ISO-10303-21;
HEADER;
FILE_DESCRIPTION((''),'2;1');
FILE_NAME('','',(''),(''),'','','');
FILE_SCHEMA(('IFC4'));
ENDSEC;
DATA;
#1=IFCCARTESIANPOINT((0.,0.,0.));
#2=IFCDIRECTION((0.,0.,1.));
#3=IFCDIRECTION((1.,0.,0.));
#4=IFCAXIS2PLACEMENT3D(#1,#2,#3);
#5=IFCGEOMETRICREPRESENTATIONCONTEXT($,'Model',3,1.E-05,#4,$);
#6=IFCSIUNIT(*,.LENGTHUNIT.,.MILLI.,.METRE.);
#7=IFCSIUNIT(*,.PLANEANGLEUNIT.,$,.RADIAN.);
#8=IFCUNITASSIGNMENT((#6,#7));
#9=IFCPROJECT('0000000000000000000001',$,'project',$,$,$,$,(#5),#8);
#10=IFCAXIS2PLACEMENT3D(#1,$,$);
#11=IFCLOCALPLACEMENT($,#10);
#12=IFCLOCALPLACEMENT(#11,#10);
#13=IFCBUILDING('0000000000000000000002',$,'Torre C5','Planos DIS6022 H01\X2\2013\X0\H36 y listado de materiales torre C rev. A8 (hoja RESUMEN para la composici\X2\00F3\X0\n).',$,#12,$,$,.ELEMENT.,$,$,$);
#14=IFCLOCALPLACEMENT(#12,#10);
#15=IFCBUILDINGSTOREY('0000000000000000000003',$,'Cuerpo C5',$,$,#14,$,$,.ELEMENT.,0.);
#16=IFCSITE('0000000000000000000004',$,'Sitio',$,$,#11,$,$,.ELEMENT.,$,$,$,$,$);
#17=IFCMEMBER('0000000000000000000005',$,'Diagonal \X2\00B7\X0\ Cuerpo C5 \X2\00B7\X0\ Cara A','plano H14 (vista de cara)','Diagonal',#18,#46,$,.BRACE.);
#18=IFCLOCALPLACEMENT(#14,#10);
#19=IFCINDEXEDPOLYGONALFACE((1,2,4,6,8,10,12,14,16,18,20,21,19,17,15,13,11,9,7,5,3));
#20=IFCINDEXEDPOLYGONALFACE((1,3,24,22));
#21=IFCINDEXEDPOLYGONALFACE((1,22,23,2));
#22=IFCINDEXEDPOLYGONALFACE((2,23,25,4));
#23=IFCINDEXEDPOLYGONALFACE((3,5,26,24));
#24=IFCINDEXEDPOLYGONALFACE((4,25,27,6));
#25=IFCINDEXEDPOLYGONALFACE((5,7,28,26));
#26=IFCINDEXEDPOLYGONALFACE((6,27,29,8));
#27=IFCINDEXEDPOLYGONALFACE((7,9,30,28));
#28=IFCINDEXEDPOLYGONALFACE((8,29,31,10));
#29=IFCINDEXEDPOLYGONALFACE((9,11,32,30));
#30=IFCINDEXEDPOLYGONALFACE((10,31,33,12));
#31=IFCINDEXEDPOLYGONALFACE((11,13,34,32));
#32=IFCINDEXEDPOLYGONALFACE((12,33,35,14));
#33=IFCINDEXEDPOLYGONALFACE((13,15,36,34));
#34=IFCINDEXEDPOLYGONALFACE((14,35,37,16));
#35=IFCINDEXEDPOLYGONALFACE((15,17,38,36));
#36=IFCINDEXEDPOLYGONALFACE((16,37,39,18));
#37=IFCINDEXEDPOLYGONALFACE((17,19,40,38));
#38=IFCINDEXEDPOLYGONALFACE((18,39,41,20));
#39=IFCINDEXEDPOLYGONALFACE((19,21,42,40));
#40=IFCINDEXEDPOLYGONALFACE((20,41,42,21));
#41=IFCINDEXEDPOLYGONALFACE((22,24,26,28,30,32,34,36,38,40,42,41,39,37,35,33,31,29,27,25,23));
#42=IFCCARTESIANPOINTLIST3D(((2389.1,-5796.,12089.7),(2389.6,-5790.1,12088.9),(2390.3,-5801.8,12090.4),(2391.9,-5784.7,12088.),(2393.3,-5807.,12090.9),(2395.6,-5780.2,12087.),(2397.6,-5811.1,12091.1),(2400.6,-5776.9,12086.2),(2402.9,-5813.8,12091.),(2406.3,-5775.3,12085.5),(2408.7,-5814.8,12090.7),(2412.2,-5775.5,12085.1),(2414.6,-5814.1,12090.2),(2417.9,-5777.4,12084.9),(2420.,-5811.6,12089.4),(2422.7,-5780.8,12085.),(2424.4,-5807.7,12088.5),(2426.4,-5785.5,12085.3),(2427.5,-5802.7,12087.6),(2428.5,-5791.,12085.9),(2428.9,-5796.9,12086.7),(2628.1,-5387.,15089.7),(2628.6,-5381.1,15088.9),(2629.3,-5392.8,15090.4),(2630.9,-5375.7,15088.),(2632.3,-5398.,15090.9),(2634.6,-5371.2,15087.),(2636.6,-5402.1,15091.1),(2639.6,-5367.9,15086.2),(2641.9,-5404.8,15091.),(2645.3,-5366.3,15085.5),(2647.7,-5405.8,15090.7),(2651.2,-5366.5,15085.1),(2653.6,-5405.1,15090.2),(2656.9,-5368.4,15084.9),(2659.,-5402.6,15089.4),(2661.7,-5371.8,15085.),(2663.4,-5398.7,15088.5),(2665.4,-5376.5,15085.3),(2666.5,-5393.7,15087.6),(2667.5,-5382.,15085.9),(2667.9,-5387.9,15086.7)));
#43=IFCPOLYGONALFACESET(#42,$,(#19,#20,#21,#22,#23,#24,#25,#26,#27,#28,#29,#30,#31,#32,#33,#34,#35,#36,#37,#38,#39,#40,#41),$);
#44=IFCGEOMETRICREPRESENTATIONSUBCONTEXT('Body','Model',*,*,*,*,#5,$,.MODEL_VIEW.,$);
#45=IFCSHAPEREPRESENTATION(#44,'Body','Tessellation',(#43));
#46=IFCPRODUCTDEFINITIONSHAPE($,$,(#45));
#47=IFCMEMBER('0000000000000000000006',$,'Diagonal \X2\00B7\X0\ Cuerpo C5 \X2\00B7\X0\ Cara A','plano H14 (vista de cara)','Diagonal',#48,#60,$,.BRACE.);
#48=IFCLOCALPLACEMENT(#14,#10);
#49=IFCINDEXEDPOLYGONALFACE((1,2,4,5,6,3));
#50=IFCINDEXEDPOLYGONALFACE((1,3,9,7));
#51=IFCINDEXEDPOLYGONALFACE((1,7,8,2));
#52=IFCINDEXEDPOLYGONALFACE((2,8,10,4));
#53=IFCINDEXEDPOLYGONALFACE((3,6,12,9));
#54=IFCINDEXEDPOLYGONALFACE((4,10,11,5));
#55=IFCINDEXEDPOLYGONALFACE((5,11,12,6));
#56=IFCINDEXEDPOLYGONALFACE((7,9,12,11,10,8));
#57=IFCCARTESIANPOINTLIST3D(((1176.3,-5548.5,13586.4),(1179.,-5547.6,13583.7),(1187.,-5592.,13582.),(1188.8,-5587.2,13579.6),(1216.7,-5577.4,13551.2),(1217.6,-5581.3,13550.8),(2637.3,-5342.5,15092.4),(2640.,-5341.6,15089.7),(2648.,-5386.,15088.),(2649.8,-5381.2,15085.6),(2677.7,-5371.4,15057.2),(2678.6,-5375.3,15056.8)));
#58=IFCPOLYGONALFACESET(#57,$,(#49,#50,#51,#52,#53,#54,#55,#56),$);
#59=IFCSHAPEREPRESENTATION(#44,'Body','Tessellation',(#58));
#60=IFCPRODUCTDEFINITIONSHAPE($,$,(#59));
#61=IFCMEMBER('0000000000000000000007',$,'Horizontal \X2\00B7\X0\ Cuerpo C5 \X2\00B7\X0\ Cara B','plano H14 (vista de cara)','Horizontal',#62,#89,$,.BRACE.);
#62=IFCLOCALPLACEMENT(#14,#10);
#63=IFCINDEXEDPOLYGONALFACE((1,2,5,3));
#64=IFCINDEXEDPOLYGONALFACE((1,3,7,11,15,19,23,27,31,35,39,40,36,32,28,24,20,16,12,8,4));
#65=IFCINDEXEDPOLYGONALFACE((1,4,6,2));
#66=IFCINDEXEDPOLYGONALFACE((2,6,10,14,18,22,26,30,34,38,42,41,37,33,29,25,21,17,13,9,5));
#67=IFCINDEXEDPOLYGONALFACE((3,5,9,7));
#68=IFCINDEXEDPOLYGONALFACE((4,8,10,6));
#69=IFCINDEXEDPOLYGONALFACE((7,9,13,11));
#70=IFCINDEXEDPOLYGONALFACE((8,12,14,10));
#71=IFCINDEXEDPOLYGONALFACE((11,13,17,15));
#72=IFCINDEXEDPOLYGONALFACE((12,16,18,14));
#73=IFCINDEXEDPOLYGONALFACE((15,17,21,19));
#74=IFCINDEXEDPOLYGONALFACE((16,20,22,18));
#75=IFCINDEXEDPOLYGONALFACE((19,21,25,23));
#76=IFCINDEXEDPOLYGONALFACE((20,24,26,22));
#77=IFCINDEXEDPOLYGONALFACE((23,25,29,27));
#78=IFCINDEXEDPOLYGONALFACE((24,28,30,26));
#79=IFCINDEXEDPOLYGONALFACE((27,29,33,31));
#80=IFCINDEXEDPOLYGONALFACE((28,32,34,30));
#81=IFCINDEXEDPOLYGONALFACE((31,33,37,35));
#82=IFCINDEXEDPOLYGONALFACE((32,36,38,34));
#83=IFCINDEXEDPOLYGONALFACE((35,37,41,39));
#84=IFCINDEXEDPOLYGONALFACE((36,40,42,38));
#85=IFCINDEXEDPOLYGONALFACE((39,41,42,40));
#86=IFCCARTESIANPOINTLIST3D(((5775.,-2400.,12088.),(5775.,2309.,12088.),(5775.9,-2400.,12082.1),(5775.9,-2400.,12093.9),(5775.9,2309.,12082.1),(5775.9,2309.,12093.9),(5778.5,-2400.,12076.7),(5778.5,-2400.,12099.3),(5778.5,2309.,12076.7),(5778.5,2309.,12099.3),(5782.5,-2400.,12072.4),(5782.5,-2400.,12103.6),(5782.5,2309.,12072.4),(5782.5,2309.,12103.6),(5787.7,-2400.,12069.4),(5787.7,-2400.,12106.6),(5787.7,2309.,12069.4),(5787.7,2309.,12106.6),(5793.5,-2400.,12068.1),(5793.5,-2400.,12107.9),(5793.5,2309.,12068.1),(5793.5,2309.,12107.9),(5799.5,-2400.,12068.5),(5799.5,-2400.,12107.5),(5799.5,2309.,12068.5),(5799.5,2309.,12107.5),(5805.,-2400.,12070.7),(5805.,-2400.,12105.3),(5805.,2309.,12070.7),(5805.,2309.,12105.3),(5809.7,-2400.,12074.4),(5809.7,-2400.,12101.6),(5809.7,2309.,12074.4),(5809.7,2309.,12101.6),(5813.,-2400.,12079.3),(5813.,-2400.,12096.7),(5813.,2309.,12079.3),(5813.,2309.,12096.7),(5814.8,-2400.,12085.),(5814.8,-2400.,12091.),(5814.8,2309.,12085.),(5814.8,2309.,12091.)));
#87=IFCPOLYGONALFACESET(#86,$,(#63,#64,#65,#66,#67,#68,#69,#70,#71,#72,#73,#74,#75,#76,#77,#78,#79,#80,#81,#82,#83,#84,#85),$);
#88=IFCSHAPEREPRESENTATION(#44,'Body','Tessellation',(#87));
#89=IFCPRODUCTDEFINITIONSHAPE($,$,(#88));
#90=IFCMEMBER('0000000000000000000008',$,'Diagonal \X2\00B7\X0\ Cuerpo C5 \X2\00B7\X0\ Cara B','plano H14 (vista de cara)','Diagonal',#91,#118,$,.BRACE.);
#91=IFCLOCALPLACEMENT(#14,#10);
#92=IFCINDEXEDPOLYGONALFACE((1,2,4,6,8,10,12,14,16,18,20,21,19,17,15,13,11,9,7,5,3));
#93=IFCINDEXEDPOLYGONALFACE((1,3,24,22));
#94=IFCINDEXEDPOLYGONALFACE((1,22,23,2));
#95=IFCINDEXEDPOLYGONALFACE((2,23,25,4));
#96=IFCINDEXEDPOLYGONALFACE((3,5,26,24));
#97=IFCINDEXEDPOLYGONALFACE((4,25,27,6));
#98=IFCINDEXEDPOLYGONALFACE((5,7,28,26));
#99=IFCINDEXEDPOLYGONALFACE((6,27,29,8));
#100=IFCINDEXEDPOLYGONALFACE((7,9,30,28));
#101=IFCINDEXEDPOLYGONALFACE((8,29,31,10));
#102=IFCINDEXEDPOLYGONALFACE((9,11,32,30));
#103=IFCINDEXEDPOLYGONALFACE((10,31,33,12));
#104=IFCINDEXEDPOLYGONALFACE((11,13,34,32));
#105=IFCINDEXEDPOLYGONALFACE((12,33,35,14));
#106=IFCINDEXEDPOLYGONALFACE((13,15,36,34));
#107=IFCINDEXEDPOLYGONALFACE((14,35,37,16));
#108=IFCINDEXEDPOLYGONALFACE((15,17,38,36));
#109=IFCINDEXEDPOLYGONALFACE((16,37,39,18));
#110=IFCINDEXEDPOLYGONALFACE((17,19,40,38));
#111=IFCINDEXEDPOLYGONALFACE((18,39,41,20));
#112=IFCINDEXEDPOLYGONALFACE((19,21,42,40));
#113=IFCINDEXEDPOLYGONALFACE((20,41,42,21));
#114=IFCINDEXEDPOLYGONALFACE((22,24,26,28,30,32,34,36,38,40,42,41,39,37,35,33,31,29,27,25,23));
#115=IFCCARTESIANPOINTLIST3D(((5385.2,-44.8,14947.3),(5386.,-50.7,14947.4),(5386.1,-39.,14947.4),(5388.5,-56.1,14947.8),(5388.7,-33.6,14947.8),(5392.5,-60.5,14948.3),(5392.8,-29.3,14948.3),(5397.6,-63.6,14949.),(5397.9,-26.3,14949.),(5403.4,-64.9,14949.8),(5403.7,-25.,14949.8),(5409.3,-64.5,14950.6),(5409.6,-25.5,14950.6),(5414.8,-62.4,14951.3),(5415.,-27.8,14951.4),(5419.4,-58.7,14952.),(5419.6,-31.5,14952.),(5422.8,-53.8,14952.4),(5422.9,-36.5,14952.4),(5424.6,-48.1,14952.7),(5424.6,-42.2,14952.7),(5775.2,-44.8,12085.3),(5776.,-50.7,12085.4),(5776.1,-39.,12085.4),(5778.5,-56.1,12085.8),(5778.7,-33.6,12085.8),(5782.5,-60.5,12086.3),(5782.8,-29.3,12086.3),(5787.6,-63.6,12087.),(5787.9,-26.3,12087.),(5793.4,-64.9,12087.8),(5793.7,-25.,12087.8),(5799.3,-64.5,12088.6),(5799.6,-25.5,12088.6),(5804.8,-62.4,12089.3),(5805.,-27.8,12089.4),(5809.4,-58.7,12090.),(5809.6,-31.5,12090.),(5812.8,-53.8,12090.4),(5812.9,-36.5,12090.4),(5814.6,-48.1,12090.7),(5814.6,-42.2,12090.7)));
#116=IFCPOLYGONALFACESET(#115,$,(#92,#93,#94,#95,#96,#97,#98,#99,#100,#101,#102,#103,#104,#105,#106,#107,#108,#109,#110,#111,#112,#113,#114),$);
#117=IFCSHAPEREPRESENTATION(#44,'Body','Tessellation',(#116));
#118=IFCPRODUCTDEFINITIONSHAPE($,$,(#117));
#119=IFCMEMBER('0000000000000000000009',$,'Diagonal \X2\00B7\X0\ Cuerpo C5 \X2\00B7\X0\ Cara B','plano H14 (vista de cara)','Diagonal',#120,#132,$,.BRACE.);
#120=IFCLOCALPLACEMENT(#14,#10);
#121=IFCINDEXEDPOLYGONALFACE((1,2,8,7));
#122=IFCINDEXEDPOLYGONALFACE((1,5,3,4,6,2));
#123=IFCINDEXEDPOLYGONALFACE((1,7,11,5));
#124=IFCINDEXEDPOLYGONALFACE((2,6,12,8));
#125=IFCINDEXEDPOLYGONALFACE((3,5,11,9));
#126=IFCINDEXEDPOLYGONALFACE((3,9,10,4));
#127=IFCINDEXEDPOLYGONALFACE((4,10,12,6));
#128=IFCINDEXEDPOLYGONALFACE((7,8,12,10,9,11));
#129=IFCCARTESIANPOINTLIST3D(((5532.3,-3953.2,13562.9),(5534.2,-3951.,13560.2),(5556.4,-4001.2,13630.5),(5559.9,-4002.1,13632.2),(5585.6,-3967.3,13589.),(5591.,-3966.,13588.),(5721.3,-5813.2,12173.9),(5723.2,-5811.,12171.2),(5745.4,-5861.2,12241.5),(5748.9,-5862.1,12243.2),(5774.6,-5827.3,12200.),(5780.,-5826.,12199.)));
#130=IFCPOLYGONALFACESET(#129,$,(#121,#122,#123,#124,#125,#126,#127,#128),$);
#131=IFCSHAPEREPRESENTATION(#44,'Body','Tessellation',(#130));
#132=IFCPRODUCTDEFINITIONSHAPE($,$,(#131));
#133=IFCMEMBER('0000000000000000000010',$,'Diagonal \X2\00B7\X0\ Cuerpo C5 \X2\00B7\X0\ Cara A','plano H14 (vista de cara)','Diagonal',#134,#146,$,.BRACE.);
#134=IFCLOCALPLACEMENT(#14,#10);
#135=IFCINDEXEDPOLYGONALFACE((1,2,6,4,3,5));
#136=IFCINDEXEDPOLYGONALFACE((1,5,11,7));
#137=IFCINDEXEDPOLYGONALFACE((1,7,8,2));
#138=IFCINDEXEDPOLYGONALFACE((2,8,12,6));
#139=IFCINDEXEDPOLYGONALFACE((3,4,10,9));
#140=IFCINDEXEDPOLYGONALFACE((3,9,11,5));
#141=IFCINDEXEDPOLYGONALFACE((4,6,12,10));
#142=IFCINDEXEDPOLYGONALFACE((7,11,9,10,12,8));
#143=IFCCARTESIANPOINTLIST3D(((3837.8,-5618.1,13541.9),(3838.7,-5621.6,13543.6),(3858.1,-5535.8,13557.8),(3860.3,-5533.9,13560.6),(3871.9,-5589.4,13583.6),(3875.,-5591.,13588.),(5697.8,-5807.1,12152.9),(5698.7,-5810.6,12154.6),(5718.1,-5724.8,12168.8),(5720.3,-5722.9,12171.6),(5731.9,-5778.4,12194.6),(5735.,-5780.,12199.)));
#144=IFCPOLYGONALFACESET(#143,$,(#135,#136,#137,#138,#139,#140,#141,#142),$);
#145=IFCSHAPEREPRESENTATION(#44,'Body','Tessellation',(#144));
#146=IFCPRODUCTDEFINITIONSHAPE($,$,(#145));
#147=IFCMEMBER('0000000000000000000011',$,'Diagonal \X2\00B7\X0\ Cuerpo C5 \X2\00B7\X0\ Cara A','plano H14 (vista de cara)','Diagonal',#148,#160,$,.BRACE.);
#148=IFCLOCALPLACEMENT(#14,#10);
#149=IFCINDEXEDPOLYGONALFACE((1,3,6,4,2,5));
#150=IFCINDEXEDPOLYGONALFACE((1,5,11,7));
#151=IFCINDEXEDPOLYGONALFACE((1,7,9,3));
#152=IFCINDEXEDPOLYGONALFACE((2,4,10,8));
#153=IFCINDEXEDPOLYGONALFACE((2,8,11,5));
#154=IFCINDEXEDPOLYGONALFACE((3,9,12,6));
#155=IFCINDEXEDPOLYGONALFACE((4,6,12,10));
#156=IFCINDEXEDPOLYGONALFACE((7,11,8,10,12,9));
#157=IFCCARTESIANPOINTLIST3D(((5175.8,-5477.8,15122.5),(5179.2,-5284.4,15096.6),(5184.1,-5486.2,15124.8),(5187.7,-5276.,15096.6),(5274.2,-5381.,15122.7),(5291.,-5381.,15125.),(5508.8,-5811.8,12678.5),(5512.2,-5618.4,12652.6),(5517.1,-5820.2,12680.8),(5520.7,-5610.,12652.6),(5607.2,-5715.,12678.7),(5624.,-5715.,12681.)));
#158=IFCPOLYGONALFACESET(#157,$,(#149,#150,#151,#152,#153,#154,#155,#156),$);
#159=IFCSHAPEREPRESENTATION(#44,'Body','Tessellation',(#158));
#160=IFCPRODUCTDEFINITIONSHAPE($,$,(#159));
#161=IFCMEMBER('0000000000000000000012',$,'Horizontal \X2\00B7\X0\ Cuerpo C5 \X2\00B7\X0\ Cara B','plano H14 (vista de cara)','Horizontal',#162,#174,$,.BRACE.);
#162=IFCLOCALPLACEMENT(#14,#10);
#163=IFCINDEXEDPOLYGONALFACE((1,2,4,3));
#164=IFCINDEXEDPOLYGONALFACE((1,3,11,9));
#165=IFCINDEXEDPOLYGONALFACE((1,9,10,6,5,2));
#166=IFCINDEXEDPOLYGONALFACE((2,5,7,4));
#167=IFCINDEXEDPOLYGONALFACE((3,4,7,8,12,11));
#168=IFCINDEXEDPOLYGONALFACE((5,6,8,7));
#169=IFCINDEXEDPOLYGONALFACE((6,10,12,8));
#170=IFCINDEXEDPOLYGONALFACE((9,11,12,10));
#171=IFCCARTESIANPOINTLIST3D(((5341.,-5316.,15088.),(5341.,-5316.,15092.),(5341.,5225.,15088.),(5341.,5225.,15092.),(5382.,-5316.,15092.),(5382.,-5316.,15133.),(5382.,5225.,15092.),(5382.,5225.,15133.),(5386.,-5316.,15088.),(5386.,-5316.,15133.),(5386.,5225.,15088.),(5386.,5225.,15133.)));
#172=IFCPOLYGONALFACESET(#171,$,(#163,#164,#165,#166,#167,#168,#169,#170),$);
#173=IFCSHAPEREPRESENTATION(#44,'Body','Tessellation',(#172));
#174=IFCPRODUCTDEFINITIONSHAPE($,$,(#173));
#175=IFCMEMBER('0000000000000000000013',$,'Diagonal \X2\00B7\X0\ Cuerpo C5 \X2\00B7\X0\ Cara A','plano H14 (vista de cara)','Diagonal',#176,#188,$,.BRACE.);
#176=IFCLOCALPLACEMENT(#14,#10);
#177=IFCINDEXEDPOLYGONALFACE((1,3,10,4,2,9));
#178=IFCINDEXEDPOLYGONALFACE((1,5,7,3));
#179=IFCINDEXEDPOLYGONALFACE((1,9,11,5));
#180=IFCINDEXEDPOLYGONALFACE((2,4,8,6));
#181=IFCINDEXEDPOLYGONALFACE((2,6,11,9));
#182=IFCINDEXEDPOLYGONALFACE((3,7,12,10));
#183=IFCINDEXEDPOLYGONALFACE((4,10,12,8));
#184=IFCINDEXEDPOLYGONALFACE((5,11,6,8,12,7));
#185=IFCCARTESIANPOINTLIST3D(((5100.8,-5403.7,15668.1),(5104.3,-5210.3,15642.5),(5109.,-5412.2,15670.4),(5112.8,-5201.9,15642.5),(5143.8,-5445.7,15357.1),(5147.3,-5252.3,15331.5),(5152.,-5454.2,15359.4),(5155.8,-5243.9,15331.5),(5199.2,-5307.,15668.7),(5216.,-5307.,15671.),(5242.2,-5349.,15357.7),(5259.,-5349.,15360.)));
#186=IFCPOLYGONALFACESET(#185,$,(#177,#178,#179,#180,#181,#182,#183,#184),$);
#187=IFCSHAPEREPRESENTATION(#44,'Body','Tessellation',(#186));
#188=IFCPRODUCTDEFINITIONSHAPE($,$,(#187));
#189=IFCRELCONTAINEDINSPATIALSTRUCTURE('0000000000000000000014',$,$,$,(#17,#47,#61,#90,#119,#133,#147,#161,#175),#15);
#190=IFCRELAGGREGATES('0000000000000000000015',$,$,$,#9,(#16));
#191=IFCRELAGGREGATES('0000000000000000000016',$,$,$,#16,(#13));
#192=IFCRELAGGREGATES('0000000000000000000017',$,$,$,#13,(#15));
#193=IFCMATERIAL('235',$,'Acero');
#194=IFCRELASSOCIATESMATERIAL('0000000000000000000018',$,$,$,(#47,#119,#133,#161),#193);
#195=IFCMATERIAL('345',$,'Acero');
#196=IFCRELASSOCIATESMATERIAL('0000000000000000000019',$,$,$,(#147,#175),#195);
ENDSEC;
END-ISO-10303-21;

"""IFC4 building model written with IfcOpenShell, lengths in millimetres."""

from ifc_helpers import new_model, si_unit, frame, frame_2d, origin, origin_with_axes, place, context, subcontext, project, spatial, circle, l_section, extrude, material, element, save


model = new_model("IFC4")

# Units and contexts
model_context = context("Model", 3, precision=1e-05, world=origin_with_axes())
body_context = subcontext(model_context, "Body", "Model", "MODEL_VIEW")
ifc_project = project(units=[si_unit("LENGTHUNIT", "METRE", prefix="MILLI"), si_unit("PLANEANGLEUNIT", "RADIAN")], contexts=[model_context])

# Site, building, storey
site_placement = place(None, origin())
site = spatial("IfcSite", under=ifc_project, at=site_placement, Name="Sitio", CompositionType="ELEMENT")
building_placement = place(site_placement, origin())
building = spatial("IfcBuilding", under=site, at=building_placement, Name="Torre C5", Description="Planos DIS6022 H01–H36 y listado de materiales torre C rev. A8 (hoja RESUMEN para la composición).", CompositionType="ELEMENT")
storey_placement = place(building_placement, origin())
storey = spatial("IfcBuildingStorey", under=building, at=storey_placement, Name="Cuerpo C5", CompositionType="ELEMENT", Elevation=0.0)

# Members
ifc_material_1 = material(Name="235", Category="Acero")
member_1_placement = place(storey_placement, frame((2409.0, -5795.0, 12088.0), z_axis=(0.078692, 0.134665, 0.987762), x_axis=(-0.420917, 0.90267, -0.089531)))
element("IfcMember", 1, at=member_1_placement, inside=storey, Name="Diagonal · Cuerpo C5 · Cara A", Description="plano H14 (vista de cara)", ObjectType="Diagonal", PredefinedType="BRACE", context=body_context, shape_type="SweptSolid", body=[
    extrude(circle(Radius=20.0), None, (0.0, 0.0, 1.0), 3037.2),
])
member_2_placement = place(storey_placement, frame((2648.0, -5386.0, 15088.0), z_axis=(-0.69297, -0.097708, -0.714314), x_axis=(-0.237561, 0.966389, 0.098273)))
element("IfcMember", 2, at=member_2_placement, inside=storey, material=ifc_material_1, Name="Diagonal · Cuerpo C5 · Cara A", Description="plano H14 (vista de cara)", ObjectType="Diagonal", PredefinedType="BRACE", context=body_context, shape_type="SweptSolid", body=[
    extrude(l_section(Depth=45.0, Width=45.0, Thickness=4.0, at=frame_2d((22.5, 22.5))), None, (0.0, 0.0, 1.0), 2108.3),
])
member_3_placement = place(storey_placement, frame((5795.0, -2400.0, 12088.0), z_axis=(0.0, 1.0, 0.0), x_axis=(-1.0, 0.0, 0.0)))
element("IfcMember", 3, at=member_3_placement, inside=storey, Name="Horizontal · Cuerpo C5 · Cara B", Description="plano H14 (vista de cara)", ObjectType="Horizontal", PredefinedType="BRACE", context=body_context, shape_type="SweptSolid", body=[
    extrude(circle(Radius=20.0), None, (0.0, 0.0, 1.0), 4709.0),
])
member_4_placement = place(storey_placement, frame((5405.0, -45.0, 14950.0), z_axis=(0.135021, 0.0, -0.990843), x_axis=(-0.99081, 0.00811, -0.135016)))
element("IfcMember", 4, at=member_4_placement, inside=storey, Name="Diagonal · Cuerpo C5 · Cara B", Description="plano H14 (vista de cara)", ObjectType="Diagonal", PredefinedType="BRACE", context=body_context, shape_type="SweptSolid", body=[
    extrude(circle(Radius=20.0), None, (0.0, 0.0, 1.0), 2888.5),
])
for number, where, z_axis, x_axis, name in (
    (5, (5780.0, -5826.0, 12199.0), (-0.081148, 0.798597, 0.596371), (-0.874162, 0.230414, -0.427492), "Diagonal · Cuerpo C5 · Cara B"),
    (6, (5735.0, -5780.0, 12199.0), (-0.798597, 0.081148, 0.596371), (-0.225777, 0.878118, -0.421821), "Diagonal · Cuerpo C5 · Cara A"),
):
    element("IfcMember", number, at=place(storey_placement, frame(where, z_axis=z_axis, x_axis=x_axis)), inside=storey, material=ifc_material_1, Name=name, Description="plano H14 (vista de cara)", ObjectType="Diagonal", PredefinedType="BRACE", context=body_context, shape_type="SweptSolid", body=[
        extrude(l_section(Depth=65.0, Width=65.0, Thickness=4.0, at=frame_2d((32.5, 32.5))), None, (0.0, 0.0, 1.0), 2329.1),
    ])
ifc_material_2 = material(Name="345", Category="Acero")
member_5_placement = place(storey_placement, frame((5624.0, -5715.0, 12681.0), z_axis=(-0.133784, 0.134185, 0.981884), x_axis=(-0.68839, 0.700155, -0.189479)))
element("IfcMember", 7, at=member_5_placement, inside=storey, material=ifc_material_2, Name="Diagonal · Cuerpo C5 · Cara A", Description="plano H14 (vista de cara)", ObjectType="Diagonal", PredefinedType="BRACE", context=body_context, shape_type="SweptSolid", body=[
    extrude(l_section(Depth=150.0, Width=150.0, Thickness=12.0, at=frame_2d((75.0, 75.0))), None, (0.0, 0.0, 1.0), 2489.1),
])
member_6_placement = place(storey_placement, frame((5386.0, -5316.0, 15088.0), z_axis=(0.0, 1.0, 0.0), x_axis=(-1.0, 0.0, 0.0)))
element("IfcMember", 8, at=member_6_placement, inside=storey, material=ifc_material_1, Name="Horizontal · Cuerpo C5 · Cara B", Description="plano H14 (vista de cara)", ObjectType="Horizontal", PredefinedType="BRACE", context=body_context, shape_type="SweptSolid", body=[
    extrude(l_section(Depth=45.0, Width=45.0, Thickness=4.0, at=frame_2d((22.5, 22.5))), None, (0.0, 0.0, 1.0), 10541.0),
])
member_7_placement = place(storey_placement, frame((5259.0, -5349.0, 15360.0), z_axis=(-0.135751, 0.132594, 0.98183), x_axis=(-0.68776, 0.700708, -0.189722)))
element("IfcMember", 9, at=member_7_placement, inside=storey, material=ifc_material_2, Name="Diagonal · Cuerpo C5 · Cara A", Description="plano H14 (vista de cara)", ObjectType="Diagonal", PredefinedType="BRACE", context=body_context, shape_type="SweptSolid", body=[
    extrude(l_section(Depth=150.0, Width=150.0, Thickness=12.0, at=frame_2d((75.0, 75.0))), None, (0.0, 0.0, 1.0), 316.8),
])

save(model, "model.ifc")
